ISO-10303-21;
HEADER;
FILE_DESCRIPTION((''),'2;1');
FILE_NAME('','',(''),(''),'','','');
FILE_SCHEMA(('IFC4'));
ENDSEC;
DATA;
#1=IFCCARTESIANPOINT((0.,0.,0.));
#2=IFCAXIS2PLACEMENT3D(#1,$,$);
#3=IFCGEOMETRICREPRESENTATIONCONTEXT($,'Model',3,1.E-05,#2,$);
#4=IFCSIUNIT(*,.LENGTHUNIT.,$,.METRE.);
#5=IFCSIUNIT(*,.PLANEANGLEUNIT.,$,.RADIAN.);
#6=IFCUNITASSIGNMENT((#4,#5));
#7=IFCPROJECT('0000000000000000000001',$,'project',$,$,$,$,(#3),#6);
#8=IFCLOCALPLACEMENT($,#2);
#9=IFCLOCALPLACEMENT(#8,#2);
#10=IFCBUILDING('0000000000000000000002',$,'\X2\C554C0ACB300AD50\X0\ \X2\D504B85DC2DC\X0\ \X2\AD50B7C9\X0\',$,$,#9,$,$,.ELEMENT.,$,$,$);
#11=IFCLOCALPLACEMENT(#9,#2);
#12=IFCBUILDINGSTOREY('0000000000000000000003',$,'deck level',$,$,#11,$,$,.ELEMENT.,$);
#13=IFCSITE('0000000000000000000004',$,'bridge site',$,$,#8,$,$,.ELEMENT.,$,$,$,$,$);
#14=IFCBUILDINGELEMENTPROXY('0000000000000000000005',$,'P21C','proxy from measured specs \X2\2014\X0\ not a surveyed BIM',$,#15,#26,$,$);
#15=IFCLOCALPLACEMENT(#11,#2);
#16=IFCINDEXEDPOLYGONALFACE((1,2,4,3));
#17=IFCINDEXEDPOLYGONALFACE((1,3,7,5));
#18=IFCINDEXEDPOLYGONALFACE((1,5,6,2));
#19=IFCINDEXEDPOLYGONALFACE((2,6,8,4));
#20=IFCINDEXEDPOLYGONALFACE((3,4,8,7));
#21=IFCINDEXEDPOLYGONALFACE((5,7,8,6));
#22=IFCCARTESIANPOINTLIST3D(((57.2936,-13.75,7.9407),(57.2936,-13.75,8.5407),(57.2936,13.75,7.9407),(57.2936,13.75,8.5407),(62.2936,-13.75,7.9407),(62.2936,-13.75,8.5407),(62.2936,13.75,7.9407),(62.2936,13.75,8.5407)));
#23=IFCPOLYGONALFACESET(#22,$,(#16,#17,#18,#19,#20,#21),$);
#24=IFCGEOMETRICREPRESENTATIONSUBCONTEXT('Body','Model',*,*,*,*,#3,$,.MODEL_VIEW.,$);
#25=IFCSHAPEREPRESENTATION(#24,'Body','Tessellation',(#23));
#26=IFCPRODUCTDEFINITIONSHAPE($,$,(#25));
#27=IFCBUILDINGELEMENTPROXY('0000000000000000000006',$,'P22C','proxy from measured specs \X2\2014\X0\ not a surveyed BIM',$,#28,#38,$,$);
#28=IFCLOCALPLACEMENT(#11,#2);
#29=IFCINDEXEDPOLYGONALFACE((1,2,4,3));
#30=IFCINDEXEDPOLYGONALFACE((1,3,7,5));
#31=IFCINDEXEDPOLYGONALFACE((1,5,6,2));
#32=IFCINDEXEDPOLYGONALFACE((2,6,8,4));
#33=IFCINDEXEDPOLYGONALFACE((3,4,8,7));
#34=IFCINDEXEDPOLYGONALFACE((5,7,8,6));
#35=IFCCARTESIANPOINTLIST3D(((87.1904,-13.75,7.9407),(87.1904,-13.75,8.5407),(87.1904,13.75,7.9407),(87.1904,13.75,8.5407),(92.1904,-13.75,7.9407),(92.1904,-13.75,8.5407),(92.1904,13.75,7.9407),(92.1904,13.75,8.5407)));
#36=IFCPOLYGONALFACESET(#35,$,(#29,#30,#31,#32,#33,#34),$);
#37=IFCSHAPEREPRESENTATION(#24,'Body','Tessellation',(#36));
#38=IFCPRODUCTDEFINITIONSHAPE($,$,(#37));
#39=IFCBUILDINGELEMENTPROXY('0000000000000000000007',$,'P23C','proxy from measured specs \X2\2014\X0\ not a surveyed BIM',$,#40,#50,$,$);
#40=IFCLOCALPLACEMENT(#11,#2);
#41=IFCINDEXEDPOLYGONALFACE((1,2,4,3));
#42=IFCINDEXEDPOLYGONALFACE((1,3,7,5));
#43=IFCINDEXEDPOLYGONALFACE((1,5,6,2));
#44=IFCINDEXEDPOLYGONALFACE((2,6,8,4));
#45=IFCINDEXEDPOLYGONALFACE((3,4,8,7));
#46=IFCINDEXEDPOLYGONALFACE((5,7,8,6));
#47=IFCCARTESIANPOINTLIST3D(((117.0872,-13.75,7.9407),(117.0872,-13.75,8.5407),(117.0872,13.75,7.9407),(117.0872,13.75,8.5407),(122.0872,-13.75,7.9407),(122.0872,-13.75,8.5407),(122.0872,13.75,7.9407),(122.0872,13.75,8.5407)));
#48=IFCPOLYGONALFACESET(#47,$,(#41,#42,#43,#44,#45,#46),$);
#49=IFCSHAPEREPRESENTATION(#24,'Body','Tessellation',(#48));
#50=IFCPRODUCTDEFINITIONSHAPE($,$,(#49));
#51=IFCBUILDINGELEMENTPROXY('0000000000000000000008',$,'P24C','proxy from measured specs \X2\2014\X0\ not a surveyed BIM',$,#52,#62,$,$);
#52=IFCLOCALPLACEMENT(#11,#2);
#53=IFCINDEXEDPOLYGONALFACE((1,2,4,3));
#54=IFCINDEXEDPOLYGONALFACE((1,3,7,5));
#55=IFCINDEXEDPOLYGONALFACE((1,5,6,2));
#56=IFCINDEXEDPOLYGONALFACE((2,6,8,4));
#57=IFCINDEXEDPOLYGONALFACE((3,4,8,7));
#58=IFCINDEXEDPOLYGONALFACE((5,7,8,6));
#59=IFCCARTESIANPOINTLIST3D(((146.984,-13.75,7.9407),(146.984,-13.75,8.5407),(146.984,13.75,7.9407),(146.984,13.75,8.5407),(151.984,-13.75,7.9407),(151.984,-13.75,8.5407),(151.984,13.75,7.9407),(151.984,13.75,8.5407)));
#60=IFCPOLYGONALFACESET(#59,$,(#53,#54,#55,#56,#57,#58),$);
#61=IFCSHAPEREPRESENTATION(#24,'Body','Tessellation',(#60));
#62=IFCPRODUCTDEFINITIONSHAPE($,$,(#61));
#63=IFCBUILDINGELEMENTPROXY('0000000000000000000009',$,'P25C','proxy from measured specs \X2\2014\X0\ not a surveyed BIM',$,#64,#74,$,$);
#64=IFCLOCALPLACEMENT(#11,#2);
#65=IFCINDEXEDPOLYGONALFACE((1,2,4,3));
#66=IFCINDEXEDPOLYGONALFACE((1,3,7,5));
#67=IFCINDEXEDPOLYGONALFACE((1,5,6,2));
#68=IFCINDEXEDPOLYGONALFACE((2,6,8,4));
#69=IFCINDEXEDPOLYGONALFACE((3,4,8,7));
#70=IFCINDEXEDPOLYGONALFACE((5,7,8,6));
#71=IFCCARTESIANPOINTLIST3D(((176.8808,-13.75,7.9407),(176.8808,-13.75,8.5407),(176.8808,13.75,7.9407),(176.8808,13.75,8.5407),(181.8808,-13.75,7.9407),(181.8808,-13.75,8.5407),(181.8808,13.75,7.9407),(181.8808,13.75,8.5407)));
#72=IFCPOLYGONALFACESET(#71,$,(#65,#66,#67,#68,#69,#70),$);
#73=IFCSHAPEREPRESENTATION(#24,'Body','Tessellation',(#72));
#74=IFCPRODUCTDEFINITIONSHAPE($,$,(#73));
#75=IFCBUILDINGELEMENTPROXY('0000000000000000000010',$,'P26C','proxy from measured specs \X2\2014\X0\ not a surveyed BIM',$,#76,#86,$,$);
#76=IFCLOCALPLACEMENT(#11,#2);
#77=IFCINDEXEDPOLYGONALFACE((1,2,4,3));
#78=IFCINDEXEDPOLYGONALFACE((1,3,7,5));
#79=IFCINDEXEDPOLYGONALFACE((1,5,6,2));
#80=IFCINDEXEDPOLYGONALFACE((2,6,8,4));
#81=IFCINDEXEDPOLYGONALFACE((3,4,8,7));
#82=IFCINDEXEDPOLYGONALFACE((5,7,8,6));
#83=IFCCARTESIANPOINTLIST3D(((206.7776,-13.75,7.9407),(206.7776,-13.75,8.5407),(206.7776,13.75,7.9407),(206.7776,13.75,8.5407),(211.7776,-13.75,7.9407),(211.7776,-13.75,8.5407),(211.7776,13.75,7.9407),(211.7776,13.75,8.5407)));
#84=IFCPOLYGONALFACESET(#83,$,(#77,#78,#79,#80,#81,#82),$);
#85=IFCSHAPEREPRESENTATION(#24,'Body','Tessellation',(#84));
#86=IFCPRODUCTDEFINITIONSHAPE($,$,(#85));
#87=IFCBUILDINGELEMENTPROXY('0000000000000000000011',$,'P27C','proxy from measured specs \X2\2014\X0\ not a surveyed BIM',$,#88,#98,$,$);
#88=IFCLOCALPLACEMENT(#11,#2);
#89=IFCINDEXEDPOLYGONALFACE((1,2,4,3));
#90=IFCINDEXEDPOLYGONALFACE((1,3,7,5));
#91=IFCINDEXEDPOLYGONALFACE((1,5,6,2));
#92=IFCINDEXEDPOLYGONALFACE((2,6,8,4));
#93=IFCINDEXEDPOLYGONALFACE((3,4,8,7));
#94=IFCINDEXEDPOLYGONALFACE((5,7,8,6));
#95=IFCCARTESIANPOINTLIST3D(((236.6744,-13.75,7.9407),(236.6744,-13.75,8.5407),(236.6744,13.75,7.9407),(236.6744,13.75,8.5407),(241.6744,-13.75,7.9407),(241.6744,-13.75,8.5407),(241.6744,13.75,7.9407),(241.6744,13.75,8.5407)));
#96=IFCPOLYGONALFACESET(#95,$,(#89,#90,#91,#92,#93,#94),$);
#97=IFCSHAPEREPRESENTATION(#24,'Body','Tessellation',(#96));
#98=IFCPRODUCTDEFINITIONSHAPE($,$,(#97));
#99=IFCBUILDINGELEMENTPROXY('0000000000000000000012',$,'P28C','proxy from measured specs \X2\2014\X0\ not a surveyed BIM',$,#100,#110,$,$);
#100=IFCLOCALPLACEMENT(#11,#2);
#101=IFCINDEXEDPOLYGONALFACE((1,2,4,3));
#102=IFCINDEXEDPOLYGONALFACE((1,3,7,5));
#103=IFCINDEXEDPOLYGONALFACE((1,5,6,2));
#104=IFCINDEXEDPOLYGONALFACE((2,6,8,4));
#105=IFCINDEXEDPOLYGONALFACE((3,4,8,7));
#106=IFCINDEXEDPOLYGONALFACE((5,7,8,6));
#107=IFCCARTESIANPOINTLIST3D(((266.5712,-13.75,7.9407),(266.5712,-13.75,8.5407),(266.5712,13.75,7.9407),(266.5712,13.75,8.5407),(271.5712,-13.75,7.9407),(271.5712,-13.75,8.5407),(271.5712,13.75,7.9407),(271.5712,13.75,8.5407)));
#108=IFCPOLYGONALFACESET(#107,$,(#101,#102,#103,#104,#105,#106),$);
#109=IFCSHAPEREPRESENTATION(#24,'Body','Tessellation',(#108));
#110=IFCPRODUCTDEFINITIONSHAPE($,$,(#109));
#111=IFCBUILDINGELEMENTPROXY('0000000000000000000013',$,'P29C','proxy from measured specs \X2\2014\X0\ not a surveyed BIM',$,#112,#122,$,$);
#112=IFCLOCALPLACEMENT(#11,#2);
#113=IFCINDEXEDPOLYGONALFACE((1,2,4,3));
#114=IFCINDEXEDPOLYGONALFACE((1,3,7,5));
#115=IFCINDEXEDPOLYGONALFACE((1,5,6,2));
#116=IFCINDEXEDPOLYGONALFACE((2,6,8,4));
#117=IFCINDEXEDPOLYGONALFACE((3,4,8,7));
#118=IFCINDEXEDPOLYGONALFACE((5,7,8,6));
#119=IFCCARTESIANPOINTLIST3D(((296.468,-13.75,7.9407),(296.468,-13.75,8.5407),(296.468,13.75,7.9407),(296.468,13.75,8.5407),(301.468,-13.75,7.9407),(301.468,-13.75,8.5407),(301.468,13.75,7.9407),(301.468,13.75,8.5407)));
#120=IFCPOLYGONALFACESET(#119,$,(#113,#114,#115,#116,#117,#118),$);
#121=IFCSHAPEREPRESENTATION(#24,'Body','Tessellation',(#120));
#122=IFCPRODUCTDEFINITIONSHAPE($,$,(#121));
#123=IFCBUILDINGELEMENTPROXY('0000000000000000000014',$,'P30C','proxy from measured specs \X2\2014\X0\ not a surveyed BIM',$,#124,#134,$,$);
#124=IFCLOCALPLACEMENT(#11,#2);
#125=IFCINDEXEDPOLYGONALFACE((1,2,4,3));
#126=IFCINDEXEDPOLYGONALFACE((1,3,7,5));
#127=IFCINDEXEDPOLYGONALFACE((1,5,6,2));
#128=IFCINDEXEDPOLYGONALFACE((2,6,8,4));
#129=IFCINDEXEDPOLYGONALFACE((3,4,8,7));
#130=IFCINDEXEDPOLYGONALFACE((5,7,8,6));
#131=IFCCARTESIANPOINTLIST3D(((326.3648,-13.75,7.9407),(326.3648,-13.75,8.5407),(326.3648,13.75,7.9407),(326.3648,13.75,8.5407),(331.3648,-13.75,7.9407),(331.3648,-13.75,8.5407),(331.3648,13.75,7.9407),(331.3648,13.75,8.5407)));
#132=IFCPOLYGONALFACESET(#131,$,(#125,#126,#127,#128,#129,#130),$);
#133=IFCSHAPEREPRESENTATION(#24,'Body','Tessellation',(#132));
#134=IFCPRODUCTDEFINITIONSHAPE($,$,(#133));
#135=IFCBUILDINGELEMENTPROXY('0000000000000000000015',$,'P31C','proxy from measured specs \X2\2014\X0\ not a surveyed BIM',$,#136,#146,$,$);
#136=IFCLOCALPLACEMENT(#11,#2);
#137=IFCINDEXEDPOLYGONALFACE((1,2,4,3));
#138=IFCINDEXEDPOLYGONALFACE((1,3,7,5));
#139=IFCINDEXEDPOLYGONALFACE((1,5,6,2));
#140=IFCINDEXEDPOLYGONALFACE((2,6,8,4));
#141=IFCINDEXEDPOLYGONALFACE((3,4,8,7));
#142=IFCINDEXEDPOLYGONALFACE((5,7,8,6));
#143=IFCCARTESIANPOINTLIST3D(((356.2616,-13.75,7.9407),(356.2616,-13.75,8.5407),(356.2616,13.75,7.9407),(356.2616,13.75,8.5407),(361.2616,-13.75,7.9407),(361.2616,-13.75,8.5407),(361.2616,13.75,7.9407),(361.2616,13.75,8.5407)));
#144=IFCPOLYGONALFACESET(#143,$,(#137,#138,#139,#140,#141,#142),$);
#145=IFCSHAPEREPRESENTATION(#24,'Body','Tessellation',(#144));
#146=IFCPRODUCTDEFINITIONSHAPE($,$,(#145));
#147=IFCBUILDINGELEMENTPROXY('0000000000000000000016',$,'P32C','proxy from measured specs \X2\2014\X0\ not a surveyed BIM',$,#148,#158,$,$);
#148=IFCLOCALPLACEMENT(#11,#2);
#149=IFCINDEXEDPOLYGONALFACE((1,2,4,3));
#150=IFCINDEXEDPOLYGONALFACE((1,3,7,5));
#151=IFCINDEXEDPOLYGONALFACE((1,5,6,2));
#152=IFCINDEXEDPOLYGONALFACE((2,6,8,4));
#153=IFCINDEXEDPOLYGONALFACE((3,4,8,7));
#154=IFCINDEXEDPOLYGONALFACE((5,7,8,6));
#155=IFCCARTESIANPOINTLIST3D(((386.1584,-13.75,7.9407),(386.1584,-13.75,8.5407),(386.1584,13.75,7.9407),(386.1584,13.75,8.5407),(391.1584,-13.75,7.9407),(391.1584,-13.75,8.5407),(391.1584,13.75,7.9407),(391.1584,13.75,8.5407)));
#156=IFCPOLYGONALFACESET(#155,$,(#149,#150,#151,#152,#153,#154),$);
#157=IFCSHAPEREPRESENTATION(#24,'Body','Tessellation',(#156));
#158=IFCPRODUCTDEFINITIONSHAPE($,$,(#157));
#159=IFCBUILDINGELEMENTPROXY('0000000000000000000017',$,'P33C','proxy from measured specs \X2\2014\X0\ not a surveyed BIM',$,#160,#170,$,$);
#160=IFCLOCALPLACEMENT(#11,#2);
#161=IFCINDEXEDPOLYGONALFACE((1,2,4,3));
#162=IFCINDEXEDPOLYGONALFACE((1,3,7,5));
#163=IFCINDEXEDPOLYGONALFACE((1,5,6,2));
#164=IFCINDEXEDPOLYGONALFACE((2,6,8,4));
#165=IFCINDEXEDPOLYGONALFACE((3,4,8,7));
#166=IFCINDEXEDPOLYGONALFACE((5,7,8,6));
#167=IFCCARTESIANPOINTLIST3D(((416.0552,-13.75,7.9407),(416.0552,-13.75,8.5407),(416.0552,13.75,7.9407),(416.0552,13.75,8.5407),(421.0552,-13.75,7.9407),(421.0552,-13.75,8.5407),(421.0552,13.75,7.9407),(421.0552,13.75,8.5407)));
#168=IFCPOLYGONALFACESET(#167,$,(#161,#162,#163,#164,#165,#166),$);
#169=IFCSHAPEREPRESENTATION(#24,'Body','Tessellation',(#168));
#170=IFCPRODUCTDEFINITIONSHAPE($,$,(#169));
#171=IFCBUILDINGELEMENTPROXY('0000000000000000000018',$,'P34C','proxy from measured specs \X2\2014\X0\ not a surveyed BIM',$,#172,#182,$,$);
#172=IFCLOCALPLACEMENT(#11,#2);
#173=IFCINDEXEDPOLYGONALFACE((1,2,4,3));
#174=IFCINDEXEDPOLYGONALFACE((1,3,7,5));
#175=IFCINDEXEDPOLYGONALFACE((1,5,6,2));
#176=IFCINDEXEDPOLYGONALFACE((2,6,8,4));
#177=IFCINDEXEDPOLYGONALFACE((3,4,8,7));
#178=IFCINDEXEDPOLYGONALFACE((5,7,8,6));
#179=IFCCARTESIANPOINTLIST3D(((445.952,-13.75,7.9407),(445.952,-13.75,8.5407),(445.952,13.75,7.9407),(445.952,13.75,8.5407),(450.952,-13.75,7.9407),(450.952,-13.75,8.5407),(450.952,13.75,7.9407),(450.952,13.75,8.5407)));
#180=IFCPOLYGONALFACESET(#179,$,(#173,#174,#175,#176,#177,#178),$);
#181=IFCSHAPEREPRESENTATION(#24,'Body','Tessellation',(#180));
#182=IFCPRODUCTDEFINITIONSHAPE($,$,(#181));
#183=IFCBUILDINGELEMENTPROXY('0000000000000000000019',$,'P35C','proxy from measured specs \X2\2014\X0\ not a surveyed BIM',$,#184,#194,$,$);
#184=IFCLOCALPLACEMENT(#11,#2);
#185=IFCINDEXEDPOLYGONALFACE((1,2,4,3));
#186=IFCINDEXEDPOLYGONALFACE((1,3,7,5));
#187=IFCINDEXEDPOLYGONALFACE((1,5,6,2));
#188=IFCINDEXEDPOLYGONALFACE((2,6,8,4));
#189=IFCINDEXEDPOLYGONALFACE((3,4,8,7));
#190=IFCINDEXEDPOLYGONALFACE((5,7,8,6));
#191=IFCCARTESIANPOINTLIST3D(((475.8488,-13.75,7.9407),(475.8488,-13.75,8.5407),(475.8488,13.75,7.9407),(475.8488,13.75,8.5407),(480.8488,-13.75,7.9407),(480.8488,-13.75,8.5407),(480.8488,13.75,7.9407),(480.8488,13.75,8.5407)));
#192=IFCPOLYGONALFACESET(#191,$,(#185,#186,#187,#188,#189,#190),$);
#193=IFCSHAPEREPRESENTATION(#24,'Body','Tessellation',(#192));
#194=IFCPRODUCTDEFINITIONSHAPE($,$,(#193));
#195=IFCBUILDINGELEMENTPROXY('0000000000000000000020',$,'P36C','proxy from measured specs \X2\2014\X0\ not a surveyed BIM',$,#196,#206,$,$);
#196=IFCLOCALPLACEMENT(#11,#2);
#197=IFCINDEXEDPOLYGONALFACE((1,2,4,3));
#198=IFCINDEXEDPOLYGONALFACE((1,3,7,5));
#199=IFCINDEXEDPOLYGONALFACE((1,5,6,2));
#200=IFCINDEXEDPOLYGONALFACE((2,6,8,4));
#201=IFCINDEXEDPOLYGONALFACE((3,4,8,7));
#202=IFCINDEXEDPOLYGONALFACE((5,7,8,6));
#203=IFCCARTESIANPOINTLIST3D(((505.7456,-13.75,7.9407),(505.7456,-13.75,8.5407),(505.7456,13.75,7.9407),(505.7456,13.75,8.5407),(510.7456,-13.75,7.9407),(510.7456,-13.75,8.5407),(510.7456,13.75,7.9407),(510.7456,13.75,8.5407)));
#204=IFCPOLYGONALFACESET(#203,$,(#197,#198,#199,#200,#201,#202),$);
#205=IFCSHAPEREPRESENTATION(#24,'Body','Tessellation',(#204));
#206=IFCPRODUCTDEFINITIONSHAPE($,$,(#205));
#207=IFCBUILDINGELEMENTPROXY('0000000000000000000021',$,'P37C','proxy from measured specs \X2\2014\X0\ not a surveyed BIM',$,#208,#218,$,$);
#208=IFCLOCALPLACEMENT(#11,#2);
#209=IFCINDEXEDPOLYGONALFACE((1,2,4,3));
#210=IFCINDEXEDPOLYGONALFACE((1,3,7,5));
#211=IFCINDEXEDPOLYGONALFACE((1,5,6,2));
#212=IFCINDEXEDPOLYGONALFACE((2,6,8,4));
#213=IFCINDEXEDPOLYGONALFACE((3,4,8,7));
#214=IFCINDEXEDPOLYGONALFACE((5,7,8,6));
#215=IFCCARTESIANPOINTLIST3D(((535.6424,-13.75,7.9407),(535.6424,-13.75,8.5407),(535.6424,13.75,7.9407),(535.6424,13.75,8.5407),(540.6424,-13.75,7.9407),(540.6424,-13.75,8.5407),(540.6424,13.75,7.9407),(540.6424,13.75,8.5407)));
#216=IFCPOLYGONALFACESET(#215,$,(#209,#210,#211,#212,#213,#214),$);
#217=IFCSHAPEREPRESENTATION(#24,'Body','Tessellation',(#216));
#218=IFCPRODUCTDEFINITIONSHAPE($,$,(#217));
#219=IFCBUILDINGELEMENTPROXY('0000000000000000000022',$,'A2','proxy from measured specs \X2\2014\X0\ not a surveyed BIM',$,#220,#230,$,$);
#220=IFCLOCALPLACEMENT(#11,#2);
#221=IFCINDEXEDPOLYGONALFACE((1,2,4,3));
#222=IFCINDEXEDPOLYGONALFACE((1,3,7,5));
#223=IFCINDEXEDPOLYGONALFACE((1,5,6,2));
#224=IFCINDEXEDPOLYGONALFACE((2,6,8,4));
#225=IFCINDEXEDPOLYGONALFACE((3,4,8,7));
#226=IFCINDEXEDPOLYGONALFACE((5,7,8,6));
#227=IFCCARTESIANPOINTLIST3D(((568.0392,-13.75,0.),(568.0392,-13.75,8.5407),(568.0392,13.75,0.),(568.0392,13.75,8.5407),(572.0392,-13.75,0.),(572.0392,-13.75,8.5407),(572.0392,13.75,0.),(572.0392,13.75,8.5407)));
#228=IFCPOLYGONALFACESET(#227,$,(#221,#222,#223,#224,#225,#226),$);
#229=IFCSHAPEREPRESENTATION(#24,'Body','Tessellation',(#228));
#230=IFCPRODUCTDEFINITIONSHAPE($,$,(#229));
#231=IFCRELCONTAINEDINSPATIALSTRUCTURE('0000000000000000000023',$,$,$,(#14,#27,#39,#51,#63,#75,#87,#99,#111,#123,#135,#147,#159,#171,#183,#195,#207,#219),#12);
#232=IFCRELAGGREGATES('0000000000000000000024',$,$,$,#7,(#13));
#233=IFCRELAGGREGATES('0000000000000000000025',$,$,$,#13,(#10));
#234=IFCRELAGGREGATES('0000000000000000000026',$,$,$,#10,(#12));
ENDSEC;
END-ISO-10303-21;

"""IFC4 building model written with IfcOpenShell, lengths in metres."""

from ifc_helpers import new_model, si_unit, frame, origin, origin_2d, place, context, subcontext, project, spatial, rectangle, extrude, element, save


model = new_model("IFC4")

# Units and contexts
model_context = context("Model", 3, precision=1e-05, world=origin())
body_context = subcontext(model_context, "Body", "Model", "MODEL_VIEW")
ifc_project = project(units=[si_unit("LENGTHUNIT", "METRE"), si_unit("PLANEANGLEUNIT", "RADIAN")], contexts=[model_context])

# Site, building, storey
site_placement = place(None, origin())
site = spatial("IfcSite", under=ifc_project, at=site_placement, Name="bridge site", CompositionType="ELEMENT")
building_placement = place(site_placement, origin())
building = spatial("IfcBuilding", under=site, at=building_placement, Name="암사대교 프록시 교량", CompositionType="ELEMENT")
storey_placement = place(building_placement, origin())
storey = spatial("IfcBuildingStorey", under=building, at=storey_placement, Name="deck level", CompositionType="ELEMENT")

# Building element proxies
for number, where, name in (
    (1, (59.7936, 0.0, 7.9407), "P21C"),
    (2, (89.6904, 0.0, 7.9407), "P22C"),
    (3, (119.5872, 0.0, 7.9407), "P23C"),
    (4, (149.484, 0.0, 7.9407), "P24C"),
    (5, (179.3808, 0.0, 7.9407), "P25C"),
    (6, (209.2776, 0.0, 7.9407), "P26C"),
    (7, (239.1744, 0.0, 7.9407), "P27C"),
    (8, (269.0712, 0.0, 7.9407), "P28C"),
    (9, (298.968, 0.0, 7.9407), "P29C"),
    (10, (328.8648, 0.0, 7.9407), "P30C"),
    (11, (358.7616, 0.0, 7.9407), "P31C"),
    (12, (388.6584, 0.0, 7.9407), "P32C"),
    (13, (418.5552, 0.0, 7.9407), "P33C"),
    (14, (448.452, 0.0, 7.9407), "P34C"),
    (15, (478.3488, 0.0, 7.9407), "P35C"),
    (16, (508.2456, 0.0, 7.9407), "P36C"),
    (17, (538.1424, 0.0, 7.9407), "P37C"),
):
    element("IfcBuildingElementProxy", number, at=place(storey_placement, frame(where)), inside=storey, Name=name, Description="proxy from measured specs — not a surveyed BIM", context=body_context, shape_type="SweptSolid", body=[
        extrude(rectangle(XDim=5.0, YDim=27.5, at=origin_2d()), origin(), (0.0, 0.0, 1.0), 0.6),
    ])
proxy_placement = place(storey_placement, frame((570.0392, 0.0, 0.0)))
element("IfcBuildingElementProxy", 18, at=proxy_placement, inside=storey, Name="A2", Description="proxy from measured specs — not a surveyed BIM", context=body_context, shape_type="SweptSolid", body=[
    extrude(rectangle(XDim=4.0, YDim=27.5, at=origin_2d()), origin(), (0.0, 0.0, 1.0), 8.5407),
])

save(model, "model.ifc")
